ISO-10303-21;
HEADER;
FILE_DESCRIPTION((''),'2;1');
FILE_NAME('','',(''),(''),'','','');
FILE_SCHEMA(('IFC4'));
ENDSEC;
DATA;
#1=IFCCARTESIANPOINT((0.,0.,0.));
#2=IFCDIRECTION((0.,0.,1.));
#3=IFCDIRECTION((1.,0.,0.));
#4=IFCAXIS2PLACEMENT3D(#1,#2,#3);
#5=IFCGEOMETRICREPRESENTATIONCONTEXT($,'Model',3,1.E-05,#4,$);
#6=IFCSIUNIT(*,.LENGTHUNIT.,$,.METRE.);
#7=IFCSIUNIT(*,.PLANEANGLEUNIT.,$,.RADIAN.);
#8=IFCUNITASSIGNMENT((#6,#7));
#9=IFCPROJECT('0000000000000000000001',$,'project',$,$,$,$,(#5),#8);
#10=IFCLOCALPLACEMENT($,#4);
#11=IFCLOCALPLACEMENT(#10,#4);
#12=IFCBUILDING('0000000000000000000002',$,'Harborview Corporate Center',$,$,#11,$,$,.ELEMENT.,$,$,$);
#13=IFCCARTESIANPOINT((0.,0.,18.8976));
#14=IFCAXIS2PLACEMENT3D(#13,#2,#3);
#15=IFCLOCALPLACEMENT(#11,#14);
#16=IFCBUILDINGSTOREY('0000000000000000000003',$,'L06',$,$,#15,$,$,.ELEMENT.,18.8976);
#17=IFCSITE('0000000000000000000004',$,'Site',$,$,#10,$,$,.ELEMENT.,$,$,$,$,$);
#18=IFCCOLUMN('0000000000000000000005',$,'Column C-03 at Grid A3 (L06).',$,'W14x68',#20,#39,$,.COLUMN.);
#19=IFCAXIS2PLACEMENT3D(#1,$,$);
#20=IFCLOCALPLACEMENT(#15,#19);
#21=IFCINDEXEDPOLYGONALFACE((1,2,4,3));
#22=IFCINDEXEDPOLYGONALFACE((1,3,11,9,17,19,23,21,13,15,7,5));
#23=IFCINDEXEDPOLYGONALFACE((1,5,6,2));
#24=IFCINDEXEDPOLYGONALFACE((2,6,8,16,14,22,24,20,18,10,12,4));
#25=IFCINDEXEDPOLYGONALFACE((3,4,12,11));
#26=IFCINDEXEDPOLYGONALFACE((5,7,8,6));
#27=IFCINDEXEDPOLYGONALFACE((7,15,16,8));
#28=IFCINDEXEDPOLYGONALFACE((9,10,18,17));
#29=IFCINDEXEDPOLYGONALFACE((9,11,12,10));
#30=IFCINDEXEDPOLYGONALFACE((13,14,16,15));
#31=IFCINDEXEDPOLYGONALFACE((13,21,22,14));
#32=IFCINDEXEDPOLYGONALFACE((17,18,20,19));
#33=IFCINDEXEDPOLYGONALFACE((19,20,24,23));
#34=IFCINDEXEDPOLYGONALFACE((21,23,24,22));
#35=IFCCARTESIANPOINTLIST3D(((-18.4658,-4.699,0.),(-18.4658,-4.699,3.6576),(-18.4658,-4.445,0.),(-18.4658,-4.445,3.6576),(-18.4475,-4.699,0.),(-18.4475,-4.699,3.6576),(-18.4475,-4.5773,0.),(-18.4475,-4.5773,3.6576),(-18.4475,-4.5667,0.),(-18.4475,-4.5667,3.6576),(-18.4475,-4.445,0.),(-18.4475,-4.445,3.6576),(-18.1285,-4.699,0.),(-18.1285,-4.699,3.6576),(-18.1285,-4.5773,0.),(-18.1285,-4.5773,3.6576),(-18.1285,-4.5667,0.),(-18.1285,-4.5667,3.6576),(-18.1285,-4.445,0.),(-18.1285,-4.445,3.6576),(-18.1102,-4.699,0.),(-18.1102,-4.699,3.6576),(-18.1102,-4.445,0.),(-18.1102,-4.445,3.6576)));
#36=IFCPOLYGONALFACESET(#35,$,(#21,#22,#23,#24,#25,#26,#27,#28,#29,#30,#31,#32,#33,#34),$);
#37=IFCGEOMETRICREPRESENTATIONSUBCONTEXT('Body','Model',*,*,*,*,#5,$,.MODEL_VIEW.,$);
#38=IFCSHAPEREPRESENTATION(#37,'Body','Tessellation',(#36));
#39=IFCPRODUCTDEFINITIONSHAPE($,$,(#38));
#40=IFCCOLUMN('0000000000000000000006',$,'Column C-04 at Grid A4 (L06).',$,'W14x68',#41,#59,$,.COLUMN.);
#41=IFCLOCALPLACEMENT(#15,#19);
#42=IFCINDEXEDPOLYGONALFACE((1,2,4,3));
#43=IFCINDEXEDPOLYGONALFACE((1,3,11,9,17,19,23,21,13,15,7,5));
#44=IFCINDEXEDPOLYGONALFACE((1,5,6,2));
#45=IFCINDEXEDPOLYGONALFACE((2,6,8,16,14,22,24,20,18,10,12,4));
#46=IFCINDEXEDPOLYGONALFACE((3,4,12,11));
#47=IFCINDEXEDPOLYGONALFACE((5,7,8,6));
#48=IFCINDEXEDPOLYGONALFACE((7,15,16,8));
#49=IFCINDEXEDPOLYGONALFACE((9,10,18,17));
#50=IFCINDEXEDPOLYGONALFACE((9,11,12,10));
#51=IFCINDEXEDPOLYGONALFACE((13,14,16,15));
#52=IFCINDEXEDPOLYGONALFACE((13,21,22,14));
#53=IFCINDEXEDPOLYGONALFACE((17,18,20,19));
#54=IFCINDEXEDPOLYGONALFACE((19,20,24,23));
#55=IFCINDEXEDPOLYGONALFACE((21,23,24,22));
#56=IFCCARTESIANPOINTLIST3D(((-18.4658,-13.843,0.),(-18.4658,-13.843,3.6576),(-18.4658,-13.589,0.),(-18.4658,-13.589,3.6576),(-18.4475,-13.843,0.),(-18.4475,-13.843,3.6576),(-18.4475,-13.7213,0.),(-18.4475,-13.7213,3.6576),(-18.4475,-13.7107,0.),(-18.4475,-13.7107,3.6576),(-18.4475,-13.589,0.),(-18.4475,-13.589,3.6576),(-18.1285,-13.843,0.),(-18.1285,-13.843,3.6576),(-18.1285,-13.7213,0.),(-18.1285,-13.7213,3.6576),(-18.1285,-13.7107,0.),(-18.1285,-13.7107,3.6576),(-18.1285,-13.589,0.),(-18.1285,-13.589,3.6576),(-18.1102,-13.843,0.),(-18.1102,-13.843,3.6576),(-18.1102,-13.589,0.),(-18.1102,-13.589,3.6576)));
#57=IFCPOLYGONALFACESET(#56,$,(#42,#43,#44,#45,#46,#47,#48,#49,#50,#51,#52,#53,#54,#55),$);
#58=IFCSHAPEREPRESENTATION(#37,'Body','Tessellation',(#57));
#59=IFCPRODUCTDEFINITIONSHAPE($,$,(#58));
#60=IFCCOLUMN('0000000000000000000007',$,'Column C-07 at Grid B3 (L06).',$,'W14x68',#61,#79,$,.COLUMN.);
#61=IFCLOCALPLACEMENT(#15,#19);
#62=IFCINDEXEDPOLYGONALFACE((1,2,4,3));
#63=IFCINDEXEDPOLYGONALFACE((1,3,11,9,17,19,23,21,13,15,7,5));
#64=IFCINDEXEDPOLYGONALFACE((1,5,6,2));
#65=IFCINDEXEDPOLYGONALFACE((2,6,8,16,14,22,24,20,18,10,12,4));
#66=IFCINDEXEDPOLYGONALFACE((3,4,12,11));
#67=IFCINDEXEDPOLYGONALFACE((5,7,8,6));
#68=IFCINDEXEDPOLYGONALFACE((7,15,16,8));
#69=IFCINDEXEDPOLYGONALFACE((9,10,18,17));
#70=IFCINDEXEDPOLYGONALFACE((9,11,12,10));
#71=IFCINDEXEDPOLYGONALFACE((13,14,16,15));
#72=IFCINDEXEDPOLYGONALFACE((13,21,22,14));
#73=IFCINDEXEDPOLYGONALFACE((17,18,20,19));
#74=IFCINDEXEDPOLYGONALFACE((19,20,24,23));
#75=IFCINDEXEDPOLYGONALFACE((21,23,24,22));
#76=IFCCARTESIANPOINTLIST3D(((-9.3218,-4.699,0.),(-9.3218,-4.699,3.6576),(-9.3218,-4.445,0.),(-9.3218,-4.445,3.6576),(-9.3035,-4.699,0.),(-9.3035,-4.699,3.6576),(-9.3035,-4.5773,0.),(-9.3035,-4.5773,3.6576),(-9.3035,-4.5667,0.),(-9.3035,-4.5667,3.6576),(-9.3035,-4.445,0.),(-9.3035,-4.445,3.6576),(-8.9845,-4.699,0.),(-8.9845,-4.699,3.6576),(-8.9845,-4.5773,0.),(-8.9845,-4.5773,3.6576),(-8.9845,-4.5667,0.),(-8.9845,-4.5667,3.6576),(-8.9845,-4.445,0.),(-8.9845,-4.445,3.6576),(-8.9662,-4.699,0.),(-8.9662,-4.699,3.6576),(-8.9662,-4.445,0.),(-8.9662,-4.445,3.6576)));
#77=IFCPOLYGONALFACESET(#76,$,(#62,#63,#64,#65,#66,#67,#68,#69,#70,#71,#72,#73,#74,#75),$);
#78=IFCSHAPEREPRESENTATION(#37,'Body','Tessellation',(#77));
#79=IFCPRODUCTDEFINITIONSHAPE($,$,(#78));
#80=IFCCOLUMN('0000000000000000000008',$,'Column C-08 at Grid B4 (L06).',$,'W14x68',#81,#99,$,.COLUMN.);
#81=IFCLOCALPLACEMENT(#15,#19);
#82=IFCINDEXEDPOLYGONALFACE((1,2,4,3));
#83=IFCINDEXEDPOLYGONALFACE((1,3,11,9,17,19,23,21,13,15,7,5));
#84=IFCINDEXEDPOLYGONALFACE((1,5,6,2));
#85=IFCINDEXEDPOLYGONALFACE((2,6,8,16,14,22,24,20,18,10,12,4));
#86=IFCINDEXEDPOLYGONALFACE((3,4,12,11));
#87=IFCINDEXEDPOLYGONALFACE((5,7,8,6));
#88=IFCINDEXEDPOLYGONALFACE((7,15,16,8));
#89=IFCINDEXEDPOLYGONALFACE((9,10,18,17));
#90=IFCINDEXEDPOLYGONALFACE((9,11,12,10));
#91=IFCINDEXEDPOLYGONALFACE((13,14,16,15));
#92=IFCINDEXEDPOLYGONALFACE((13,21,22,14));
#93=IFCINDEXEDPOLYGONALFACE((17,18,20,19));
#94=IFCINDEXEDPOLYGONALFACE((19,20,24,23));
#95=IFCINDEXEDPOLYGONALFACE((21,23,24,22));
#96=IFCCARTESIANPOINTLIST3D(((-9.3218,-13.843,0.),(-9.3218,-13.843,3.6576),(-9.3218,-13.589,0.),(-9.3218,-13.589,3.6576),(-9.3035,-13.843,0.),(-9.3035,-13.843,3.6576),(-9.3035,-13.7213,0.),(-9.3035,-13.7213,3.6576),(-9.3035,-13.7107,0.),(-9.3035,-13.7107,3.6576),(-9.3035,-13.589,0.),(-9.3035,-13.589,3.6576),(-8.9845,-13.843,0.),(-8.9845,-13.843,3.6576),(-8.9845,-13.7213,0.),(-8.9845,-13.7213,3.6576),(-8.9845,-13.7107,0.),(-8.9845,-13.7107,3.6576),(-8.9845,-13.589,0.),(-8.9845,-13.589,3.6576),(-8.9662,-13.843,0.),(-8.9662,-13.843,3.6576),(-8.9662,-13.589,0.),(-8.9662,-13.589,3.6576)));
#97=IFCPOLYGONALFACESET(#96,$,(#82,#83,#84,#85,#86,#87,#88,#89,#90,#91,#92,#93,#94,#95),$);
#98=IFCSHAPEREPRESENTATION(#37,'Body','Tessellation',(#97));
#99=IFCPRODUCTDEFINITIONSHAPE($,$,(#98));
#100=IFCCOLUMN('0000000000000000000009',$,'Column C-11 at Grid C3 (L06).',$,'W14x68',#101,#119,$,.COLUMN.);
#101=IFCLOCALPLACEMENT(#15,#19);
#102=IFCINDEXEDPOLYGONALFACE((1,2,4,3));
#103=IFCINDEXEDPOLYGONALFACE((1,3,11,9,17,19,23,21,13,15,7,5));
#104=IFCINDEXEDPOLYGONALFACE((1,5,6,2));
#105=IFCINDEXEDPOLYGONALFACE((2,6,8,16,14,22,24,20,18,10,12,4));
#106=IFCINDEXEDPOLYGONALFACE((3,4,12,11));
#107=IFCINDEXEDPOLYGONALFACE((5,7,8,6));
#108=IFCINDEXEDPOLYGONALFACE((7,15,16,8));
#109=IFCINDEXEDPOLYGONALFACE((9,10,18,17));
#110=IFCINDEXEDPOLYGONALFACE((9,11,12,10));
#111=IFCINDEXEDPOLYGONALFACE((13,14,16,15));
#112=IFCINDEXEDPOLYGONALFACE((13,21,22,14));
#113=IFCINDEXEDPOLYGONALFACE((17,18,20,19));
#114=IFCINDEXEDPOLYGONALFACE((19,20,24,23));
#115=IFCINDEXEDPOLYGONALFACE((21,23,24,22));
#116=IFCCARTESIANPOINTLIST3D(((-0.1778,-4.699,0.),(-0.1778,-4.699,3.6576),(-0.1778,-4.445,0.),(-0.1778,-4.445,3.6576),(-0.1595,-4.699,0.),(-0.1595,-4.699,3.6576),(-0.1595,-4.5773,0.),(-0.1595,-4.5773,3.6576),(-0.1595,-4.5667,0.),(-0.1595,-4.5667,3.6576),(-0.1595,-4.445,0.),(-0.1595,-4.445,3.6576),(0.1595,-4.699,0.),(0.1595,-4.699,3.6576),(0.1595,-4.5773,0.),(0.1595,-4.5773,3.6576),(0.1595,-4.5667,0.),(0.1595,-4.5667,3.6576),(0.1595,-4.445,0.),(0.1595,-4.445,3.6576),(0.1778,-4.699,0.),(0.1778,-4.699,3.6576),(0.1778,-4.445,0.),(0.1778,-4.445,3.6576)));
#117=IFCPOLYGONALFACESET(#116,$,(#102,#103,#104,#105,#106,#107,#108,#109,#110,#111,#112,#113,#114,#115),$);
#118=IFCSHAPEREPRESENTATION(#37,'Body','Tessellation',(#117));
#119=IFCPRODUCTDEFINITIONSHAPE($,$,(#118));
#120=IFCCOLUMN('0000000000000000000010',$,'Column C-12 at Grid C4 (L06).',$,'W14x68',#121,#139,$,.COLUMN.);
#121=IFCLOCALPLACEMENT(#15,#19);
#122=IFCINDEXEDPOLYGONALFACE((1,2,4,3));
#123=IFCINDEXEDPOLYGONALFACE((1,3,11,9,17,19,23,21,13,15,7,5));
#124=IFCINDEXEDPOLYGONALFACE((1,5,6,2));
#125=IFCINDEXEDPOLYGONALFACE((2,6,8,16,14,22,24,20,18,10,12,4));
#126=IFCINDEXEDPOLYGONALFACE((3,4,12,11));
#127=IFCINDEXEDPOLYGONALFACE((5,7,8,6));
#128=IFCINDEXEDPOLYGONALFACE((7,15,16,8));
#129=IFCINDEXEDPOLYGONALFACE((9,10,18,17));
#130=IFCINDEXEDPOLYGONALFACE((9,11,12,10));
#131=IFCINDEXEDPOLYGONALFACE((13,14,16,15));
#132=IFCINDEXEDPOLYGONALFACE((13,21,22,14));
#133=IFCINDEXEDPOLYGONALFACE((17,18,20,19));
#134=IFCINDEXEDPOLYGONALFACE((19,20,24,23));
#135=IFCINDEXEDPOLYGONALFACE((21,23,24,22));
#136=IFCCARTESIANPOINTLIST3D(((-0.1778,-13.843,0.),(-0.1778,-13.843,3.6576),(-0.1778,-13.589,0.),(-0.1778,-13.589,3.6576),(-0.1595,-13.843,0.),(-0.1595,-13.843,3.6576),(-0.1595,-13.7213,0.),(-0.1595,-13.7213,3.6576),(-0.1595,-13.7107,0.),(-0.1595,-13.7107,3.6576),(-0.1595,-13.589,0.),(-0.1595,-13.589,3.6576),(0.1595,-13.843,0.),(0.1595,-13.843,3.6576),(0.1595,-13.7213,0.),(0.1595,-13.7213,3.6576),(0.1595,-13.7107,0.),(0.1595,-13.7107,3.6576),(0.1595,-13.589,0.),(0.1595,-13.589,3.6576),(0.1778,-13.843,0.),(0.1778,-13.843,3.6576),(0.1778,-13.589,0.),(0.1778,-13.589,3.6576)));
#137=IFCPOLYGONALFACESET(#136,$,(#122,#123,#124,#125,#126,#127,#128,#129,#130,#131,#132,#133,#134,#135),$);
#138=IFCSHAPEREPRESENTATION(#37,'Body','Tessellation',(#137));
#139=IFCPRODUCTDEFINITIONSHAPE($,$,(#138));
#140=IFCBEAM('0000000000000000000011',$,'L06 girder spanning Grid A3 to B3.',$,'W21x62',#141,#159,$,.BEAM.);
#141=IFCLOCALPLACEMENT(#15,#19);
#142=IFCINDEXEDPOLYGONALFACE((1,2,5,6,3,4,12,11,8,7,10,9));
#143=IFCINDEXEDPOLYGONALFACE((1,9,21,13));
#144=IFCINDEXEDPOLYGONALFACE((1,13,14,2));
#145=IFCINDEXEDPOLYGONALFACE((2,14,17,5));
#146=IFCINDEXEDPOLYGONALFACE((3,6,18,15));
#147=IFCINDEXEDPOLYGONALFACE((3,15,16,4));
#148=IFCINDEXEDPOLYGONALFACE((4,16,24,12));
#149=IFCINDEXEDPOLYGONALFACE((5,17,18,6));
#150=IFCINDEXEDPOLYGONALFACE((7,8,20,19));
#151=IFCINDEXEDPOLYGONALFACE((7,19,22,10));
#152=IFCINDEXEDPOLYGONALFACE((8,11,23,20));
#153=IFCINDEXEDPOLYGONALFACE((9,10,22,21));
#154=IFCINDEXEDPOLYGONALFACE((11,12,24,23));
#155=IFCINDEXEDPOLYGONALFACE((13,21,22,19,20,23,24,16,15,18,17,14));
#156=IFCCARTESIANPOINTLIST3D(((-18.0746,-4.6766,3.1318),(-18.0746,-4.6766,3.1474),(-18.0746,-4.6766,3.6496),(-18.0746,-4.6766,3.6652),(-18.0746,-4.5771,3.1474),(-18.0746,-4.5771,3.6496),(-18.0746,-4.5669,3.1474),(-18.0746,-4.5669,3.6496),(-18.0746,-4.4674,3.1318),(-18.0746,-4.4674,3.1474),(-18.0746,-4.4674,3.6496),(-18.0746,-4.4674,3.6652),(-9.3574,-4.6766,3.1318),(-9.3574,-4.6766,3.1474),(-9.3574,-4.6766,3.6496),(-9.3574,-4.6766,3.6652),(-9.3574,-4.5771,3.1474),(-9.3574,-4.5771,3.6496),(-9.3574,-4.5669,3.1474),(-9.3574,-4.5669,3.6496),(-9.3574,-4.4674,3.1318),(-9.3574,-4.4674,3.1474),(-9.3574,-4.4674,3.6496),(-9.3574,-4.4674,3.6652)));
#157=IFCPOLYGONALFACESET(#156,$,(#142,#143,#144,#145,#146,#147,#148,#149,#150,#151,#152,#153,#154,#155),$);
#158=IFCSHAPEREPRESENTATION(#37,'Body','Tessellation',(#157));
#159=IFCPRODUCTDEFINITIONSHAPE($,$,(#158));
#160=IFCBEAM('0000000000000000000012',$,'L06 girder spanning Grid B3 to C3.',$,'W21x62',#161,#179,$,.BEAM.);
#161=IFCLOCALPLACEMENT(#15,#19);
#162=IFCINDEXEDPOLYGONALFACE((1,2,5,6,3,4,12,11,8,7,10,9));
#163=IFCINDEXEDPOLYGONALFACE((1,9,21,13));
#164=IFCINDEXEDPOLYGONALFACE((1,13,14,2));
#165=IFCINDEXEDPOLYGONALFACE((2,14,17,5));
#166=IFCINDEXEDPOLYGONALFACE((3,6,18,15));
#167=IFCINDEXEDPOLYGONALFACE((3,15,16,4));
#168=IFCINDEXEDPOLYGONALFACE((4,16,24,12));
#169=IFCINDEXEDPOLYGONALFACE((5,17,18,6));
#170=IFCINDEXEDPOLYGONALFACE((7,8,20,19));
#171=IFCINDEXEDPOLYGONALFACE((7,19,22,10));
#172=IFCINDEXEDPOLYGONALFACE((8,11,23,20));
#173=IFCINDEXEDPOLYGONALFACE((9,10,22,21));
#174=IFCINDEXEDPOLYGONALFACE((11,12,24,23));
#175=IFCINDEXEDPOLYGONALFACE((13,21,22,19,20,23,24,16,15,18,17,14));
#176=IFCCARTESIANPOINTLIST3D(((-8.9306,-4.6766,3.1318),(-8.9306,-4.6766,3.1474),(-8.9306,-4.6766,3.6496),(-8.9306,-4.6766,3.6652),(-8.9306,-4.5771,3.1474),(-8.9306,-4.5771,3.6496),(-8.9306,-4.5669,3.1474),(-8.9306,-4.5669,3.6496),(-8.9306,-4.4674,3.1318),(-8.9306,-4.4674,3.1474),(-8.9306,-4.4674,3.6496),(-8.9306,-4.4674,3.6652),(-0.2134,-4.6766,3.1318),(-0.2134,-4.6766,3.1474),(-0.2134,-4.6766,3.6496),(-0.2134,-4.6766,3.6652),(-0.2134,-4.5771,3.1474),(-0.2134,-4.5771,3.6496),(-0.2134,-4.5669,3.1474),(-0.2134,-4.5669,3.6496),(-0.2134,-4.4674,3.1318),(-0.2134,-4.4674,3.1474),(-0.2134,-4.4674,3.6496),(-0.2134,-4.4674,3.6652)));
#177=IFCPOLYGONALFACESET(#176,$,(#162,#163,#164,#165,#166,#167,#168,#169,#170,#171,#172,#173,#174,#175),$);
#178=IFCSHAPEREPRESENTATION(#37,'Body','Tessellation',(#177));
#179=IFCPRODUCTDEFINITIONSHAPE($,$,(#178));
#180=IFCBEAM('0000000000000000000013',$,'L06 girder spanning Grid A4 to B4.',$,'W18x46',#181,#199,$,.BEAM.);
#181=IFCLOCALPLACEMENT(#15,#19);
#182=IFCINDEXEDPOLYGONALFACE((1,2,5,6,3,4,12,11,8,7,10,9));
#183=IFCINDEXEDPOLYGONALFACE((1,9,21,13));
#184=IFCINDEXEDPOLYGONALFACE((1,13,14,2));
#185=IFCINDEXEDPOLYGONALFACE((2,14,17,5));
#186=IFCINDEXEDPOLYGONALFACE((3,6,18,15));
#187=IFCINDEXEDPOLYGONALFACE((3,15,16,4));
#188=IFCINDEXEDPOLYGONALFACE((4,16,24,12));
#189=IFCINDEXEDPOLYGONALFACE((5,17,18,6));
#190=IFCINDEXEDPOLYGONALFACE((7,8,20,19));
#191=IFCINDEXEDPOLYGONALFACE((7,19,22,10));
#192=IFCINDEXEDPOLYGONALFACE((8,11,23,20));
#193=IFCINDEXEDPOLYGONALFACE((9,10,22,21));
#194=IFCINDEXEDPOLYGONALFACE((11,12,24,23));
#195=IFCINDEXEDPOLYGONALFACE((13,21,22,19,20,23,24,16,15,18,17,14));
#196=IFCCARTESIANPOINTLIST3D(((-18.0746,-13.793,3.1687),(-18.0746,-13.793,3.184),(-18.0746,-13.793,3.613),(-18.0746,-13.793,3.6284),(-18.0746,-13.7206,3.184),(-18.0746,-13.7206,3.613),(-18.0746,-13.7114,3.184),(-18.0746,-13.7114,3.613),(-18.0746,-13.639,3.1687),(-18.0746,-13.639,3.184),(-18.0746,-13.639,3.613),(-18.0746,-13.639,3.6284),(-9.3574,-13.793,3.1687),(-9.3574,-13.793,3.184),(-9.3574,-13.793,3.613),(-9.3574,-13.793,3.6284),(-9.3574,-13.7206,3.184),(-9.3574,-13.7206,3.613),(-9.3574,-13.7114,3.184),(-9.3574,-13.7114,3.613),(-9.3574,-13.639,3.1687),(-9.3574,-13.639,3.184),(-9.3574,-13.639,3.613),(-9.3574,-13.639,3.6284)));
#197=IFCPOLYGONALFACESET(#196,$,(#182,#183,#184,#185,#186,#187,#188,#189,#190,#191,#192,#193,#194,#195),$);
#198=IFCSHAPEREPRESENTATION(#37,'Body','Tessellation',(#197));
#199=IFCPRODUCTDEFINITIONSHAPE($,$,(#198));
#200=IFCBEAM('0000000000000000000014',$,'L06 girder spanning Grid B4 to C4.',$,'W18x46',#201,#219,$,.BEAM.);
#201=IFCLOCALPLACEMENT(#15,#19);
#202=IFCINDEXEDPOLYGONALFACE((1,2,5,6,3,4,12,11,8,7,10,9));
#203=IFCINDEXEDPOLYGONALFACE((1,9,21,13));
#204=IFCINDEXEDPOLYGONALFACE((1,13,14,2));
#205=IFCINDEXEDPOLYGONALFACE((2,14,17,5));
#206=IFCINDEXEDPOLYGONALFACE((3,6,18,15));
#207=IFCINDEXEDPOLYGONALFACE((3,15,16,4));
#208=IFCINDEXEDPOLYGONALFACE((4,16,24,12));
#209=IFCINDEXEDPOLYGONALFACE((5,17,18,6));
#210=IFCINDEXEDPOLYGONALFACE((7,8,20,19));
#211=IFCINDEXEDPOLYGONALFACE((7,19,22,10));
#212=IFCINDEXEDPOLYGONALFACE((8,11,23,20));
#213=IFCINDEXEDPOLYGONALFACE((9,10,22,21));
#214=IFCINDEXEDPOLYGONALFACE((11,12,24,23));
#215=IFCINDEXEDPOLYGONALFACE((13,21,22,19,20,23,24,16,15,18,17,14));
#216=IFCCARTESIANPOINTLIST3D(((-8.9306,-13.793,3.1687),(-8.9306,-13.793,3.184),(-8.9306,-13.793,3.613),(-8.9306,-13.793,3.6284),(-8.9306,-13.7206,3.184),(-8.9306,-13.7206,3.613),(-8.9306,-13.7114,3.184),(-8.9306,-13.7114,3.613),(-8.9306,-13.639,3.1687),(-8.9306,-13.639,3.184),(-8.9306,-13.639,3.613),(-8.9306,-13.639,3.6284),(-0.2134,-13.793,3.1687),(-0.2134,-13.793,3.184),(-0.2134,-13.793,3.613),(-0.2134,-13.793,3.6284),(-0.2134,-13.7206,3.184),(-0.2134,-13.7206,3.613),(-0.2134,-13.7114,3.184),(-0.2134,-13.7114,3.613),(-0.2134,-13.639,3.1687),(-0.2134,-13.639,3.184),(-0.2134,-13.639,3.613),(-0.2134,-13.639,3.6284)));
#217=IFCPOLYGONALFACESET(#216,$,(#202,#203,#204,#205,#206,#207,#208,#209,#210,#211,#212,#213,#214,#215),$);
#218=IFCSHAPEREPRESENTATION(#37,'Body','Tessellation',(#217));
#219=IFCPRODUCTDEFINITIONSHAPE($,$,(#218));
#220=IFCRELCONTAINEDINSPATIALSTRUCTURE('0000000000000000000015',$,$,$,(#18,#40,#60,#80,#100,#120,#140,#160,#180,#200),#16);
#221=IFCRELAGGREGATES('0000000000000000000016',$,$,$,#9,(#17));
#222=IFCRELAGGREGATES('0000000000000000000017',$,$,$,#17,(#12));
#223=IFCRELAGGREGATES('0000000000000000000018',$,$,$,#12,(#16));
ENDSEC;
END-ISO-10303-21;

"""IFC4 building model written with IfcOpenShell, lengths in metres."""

from ifc_helpers import new_model, si_unit, frame, origin_with_axes, place, context, subcontext, project, spatial, i_section, extrude, element, save


model = new_model("IFC4")

# Units and contexts
model_context = context("Model", 3, precision=1e-05, world=origin_with_axes())
body_context = subcontext(model_context, "Body", "Model", "MODEL_VIEW")
ifc_project = project(units=[si_unit("LENGTHUNIT", "METRE"), si_unit("PLANEANGLEUNIT", "RADIAN")], contexts=[model_context])

# Site, building, storey
site_placement = place(None, origin_with_axes())
site = spatial("IfcSite", under=ifc_project, at=site_placement, Name="Site", CompositionType="ELEMENT")
building_placement = place(site_placement, origin_with_axes())
building = spatial("IfcBuilding", under=site, at=building_placement, Name="Harborview Corporate Center", CompositionType="ELEMENT")
storey_placement = place(building_placement, frame((0.0, 0.0, 18.8976), z_axis=(0.0, 0.0, 1.0), x_axis=(1.0, 0.0, 0.0)))
storey = spatial("IfcBuildingStorey", under=building, at=storey_placement, Name="L06", CompositionType="ELEMENT", Elevation=18.8976)

# Columns
for number, where, z_axis, x_axis, name in (
    (1, (-18.288, -4.572, 0.0), (0.0, 0.0, 1.0), (0.0, 1.0, 0.0), "Column C-03 at Grid A3 (L06)."),
    (2, (-18.288, -13.716, 0.0), (0.0, 0.0, 1.0), (0.0, 1.0, 0.0), "Column C-04 at Grid A4 (L06)."),
    (3, (-9.144, -4.572, 0.0), (0.0, 0.0, 1.0), (0.0, 1.0, 0.0), "Column C-07 at Grid B3 (L06)."),
    (4, (-9.144, -13.716, 0.0), (0.0, 0.0, 1.0), (0.0, 1.0, 0.0), "Column C-08 at Grid B4 (L06)."),
    (5, (0.0, -4.572, 0.0), (0.0, 0.0, 1.0), (0.0, 1.0, 0.0), "Column C-11 at Grid C3 (L06)."),
    (6, (0.0, -13.716, 0.0), (0.0, 0.0, 1.0), (0.0, 1.0, 0.0), "Column C-12 at Grid C4 (L06)."),
):
    element("IfcColumn", number, at=place(storey_placement, frame(where, z_axis=z_axis, x_axis=x_axis)), inside=storey, Name=name, ObjectType="W14x68", PredefinedType="COLUMN", context=body_context, shape_type="SweptSolid", body=[
        extrude(i_section(OverallWidth=0.254, OverallDepth=0.3556, WebThickness=0.0105, FlangeThickness=0.0183), origin_with_axes(), (0.0, 0.0, 1.0), 3.6576),
    ])

# Beams
beam_1_placement = place(storey_placement, frame((-18.0746, -4.572, 3.3985), z_axis=(1.0, 0.0, 0.0), x_axis=(0.0, 1.0, 0.0)))
element("IfcBeam", 7, at=beam_1_placement, inside=storey, Name="L06 girder spanning Grid A3 to B3.", ObjectType="W21x62", PredefinedType="BEAM", context=body_context, shape_type="SweptSolid", body=[
    extrude(i_section(OverallWidth=0.2093, OverallDepth=0.5334, WebThickness=0.0102, FlangeThickness=0.0156), origin_with_axes(), (0.0, 0.0, 1.0), 8.7173),
])
beam_2_placement = place(storey_placement, frame((-8.9306, -4.572, 3.3985), z_axis=(1.0, 0.0, 0.0), x_axis=(0.0, 1.0, 0.0)))
element("IfcBeam", 8, at=beam_2_placement, inside=storey, Name="L06 girder spanning Grid B3 to C3.", ObjectType="W21x62", PredefinedType="BEAM", context=body_context, shape_type="SweptSolid", body=[
    extrude(i_section(OverallWidth=0.2093, OverallDepth=0.5334, WebThickness=0.0102, FlangeThickness=0.0156), origin_with_axes(), (0.0, 0.0, 1.0), 8.7173),
])
beam_3_placement = place(storey_placement, frame((-18.0746, -13.716, 3.3985), z_axis=(1.0, 0.0, 0.0), x_axis=(0.0, 1.0, 0.0)))
element("IfcBeam", 9, at=beam_3_placement, inside=storey, Name="L06 girder spanning Grid A4 to B4.", ObjectType="W18x46", PredefinedType="BEAM", context=body_context, shape_type="SweptSolid", body=[
    extrude(i_section(OverallWidth=0.1539, OverallDepth=0.4597, WebThickness=0.0091, FlangeThickness=0.0154), origin_with_axes(), (0.0, 0.0, 1.0), 8.7173),
])
beam_4_placement = place(storey_placement, frame((-8.9306, -13.716, 3.3985), z_axis=(1.0, 0.0, 0.0), x_axis=(0.0, 1.0, 0.0)))
element("IfcBeam", 10, at=beam_4_placement, inside=storey, Name="L06 girder spanning Grid B4 to C4.", ObjectType="W18x46", PredefinedType="BEAM", context=body_context, shape_type="SweptSolid", body=[
    extrude(i_section(OverallWidth=0.1539, OverallDepth=0.4597, WebThickness=0.0091, FlangeThickness=0.0154), origin_with_axes(), (0.0, 0.0, 1.0), 8.7173),
])

save(model, "model.ifc")
